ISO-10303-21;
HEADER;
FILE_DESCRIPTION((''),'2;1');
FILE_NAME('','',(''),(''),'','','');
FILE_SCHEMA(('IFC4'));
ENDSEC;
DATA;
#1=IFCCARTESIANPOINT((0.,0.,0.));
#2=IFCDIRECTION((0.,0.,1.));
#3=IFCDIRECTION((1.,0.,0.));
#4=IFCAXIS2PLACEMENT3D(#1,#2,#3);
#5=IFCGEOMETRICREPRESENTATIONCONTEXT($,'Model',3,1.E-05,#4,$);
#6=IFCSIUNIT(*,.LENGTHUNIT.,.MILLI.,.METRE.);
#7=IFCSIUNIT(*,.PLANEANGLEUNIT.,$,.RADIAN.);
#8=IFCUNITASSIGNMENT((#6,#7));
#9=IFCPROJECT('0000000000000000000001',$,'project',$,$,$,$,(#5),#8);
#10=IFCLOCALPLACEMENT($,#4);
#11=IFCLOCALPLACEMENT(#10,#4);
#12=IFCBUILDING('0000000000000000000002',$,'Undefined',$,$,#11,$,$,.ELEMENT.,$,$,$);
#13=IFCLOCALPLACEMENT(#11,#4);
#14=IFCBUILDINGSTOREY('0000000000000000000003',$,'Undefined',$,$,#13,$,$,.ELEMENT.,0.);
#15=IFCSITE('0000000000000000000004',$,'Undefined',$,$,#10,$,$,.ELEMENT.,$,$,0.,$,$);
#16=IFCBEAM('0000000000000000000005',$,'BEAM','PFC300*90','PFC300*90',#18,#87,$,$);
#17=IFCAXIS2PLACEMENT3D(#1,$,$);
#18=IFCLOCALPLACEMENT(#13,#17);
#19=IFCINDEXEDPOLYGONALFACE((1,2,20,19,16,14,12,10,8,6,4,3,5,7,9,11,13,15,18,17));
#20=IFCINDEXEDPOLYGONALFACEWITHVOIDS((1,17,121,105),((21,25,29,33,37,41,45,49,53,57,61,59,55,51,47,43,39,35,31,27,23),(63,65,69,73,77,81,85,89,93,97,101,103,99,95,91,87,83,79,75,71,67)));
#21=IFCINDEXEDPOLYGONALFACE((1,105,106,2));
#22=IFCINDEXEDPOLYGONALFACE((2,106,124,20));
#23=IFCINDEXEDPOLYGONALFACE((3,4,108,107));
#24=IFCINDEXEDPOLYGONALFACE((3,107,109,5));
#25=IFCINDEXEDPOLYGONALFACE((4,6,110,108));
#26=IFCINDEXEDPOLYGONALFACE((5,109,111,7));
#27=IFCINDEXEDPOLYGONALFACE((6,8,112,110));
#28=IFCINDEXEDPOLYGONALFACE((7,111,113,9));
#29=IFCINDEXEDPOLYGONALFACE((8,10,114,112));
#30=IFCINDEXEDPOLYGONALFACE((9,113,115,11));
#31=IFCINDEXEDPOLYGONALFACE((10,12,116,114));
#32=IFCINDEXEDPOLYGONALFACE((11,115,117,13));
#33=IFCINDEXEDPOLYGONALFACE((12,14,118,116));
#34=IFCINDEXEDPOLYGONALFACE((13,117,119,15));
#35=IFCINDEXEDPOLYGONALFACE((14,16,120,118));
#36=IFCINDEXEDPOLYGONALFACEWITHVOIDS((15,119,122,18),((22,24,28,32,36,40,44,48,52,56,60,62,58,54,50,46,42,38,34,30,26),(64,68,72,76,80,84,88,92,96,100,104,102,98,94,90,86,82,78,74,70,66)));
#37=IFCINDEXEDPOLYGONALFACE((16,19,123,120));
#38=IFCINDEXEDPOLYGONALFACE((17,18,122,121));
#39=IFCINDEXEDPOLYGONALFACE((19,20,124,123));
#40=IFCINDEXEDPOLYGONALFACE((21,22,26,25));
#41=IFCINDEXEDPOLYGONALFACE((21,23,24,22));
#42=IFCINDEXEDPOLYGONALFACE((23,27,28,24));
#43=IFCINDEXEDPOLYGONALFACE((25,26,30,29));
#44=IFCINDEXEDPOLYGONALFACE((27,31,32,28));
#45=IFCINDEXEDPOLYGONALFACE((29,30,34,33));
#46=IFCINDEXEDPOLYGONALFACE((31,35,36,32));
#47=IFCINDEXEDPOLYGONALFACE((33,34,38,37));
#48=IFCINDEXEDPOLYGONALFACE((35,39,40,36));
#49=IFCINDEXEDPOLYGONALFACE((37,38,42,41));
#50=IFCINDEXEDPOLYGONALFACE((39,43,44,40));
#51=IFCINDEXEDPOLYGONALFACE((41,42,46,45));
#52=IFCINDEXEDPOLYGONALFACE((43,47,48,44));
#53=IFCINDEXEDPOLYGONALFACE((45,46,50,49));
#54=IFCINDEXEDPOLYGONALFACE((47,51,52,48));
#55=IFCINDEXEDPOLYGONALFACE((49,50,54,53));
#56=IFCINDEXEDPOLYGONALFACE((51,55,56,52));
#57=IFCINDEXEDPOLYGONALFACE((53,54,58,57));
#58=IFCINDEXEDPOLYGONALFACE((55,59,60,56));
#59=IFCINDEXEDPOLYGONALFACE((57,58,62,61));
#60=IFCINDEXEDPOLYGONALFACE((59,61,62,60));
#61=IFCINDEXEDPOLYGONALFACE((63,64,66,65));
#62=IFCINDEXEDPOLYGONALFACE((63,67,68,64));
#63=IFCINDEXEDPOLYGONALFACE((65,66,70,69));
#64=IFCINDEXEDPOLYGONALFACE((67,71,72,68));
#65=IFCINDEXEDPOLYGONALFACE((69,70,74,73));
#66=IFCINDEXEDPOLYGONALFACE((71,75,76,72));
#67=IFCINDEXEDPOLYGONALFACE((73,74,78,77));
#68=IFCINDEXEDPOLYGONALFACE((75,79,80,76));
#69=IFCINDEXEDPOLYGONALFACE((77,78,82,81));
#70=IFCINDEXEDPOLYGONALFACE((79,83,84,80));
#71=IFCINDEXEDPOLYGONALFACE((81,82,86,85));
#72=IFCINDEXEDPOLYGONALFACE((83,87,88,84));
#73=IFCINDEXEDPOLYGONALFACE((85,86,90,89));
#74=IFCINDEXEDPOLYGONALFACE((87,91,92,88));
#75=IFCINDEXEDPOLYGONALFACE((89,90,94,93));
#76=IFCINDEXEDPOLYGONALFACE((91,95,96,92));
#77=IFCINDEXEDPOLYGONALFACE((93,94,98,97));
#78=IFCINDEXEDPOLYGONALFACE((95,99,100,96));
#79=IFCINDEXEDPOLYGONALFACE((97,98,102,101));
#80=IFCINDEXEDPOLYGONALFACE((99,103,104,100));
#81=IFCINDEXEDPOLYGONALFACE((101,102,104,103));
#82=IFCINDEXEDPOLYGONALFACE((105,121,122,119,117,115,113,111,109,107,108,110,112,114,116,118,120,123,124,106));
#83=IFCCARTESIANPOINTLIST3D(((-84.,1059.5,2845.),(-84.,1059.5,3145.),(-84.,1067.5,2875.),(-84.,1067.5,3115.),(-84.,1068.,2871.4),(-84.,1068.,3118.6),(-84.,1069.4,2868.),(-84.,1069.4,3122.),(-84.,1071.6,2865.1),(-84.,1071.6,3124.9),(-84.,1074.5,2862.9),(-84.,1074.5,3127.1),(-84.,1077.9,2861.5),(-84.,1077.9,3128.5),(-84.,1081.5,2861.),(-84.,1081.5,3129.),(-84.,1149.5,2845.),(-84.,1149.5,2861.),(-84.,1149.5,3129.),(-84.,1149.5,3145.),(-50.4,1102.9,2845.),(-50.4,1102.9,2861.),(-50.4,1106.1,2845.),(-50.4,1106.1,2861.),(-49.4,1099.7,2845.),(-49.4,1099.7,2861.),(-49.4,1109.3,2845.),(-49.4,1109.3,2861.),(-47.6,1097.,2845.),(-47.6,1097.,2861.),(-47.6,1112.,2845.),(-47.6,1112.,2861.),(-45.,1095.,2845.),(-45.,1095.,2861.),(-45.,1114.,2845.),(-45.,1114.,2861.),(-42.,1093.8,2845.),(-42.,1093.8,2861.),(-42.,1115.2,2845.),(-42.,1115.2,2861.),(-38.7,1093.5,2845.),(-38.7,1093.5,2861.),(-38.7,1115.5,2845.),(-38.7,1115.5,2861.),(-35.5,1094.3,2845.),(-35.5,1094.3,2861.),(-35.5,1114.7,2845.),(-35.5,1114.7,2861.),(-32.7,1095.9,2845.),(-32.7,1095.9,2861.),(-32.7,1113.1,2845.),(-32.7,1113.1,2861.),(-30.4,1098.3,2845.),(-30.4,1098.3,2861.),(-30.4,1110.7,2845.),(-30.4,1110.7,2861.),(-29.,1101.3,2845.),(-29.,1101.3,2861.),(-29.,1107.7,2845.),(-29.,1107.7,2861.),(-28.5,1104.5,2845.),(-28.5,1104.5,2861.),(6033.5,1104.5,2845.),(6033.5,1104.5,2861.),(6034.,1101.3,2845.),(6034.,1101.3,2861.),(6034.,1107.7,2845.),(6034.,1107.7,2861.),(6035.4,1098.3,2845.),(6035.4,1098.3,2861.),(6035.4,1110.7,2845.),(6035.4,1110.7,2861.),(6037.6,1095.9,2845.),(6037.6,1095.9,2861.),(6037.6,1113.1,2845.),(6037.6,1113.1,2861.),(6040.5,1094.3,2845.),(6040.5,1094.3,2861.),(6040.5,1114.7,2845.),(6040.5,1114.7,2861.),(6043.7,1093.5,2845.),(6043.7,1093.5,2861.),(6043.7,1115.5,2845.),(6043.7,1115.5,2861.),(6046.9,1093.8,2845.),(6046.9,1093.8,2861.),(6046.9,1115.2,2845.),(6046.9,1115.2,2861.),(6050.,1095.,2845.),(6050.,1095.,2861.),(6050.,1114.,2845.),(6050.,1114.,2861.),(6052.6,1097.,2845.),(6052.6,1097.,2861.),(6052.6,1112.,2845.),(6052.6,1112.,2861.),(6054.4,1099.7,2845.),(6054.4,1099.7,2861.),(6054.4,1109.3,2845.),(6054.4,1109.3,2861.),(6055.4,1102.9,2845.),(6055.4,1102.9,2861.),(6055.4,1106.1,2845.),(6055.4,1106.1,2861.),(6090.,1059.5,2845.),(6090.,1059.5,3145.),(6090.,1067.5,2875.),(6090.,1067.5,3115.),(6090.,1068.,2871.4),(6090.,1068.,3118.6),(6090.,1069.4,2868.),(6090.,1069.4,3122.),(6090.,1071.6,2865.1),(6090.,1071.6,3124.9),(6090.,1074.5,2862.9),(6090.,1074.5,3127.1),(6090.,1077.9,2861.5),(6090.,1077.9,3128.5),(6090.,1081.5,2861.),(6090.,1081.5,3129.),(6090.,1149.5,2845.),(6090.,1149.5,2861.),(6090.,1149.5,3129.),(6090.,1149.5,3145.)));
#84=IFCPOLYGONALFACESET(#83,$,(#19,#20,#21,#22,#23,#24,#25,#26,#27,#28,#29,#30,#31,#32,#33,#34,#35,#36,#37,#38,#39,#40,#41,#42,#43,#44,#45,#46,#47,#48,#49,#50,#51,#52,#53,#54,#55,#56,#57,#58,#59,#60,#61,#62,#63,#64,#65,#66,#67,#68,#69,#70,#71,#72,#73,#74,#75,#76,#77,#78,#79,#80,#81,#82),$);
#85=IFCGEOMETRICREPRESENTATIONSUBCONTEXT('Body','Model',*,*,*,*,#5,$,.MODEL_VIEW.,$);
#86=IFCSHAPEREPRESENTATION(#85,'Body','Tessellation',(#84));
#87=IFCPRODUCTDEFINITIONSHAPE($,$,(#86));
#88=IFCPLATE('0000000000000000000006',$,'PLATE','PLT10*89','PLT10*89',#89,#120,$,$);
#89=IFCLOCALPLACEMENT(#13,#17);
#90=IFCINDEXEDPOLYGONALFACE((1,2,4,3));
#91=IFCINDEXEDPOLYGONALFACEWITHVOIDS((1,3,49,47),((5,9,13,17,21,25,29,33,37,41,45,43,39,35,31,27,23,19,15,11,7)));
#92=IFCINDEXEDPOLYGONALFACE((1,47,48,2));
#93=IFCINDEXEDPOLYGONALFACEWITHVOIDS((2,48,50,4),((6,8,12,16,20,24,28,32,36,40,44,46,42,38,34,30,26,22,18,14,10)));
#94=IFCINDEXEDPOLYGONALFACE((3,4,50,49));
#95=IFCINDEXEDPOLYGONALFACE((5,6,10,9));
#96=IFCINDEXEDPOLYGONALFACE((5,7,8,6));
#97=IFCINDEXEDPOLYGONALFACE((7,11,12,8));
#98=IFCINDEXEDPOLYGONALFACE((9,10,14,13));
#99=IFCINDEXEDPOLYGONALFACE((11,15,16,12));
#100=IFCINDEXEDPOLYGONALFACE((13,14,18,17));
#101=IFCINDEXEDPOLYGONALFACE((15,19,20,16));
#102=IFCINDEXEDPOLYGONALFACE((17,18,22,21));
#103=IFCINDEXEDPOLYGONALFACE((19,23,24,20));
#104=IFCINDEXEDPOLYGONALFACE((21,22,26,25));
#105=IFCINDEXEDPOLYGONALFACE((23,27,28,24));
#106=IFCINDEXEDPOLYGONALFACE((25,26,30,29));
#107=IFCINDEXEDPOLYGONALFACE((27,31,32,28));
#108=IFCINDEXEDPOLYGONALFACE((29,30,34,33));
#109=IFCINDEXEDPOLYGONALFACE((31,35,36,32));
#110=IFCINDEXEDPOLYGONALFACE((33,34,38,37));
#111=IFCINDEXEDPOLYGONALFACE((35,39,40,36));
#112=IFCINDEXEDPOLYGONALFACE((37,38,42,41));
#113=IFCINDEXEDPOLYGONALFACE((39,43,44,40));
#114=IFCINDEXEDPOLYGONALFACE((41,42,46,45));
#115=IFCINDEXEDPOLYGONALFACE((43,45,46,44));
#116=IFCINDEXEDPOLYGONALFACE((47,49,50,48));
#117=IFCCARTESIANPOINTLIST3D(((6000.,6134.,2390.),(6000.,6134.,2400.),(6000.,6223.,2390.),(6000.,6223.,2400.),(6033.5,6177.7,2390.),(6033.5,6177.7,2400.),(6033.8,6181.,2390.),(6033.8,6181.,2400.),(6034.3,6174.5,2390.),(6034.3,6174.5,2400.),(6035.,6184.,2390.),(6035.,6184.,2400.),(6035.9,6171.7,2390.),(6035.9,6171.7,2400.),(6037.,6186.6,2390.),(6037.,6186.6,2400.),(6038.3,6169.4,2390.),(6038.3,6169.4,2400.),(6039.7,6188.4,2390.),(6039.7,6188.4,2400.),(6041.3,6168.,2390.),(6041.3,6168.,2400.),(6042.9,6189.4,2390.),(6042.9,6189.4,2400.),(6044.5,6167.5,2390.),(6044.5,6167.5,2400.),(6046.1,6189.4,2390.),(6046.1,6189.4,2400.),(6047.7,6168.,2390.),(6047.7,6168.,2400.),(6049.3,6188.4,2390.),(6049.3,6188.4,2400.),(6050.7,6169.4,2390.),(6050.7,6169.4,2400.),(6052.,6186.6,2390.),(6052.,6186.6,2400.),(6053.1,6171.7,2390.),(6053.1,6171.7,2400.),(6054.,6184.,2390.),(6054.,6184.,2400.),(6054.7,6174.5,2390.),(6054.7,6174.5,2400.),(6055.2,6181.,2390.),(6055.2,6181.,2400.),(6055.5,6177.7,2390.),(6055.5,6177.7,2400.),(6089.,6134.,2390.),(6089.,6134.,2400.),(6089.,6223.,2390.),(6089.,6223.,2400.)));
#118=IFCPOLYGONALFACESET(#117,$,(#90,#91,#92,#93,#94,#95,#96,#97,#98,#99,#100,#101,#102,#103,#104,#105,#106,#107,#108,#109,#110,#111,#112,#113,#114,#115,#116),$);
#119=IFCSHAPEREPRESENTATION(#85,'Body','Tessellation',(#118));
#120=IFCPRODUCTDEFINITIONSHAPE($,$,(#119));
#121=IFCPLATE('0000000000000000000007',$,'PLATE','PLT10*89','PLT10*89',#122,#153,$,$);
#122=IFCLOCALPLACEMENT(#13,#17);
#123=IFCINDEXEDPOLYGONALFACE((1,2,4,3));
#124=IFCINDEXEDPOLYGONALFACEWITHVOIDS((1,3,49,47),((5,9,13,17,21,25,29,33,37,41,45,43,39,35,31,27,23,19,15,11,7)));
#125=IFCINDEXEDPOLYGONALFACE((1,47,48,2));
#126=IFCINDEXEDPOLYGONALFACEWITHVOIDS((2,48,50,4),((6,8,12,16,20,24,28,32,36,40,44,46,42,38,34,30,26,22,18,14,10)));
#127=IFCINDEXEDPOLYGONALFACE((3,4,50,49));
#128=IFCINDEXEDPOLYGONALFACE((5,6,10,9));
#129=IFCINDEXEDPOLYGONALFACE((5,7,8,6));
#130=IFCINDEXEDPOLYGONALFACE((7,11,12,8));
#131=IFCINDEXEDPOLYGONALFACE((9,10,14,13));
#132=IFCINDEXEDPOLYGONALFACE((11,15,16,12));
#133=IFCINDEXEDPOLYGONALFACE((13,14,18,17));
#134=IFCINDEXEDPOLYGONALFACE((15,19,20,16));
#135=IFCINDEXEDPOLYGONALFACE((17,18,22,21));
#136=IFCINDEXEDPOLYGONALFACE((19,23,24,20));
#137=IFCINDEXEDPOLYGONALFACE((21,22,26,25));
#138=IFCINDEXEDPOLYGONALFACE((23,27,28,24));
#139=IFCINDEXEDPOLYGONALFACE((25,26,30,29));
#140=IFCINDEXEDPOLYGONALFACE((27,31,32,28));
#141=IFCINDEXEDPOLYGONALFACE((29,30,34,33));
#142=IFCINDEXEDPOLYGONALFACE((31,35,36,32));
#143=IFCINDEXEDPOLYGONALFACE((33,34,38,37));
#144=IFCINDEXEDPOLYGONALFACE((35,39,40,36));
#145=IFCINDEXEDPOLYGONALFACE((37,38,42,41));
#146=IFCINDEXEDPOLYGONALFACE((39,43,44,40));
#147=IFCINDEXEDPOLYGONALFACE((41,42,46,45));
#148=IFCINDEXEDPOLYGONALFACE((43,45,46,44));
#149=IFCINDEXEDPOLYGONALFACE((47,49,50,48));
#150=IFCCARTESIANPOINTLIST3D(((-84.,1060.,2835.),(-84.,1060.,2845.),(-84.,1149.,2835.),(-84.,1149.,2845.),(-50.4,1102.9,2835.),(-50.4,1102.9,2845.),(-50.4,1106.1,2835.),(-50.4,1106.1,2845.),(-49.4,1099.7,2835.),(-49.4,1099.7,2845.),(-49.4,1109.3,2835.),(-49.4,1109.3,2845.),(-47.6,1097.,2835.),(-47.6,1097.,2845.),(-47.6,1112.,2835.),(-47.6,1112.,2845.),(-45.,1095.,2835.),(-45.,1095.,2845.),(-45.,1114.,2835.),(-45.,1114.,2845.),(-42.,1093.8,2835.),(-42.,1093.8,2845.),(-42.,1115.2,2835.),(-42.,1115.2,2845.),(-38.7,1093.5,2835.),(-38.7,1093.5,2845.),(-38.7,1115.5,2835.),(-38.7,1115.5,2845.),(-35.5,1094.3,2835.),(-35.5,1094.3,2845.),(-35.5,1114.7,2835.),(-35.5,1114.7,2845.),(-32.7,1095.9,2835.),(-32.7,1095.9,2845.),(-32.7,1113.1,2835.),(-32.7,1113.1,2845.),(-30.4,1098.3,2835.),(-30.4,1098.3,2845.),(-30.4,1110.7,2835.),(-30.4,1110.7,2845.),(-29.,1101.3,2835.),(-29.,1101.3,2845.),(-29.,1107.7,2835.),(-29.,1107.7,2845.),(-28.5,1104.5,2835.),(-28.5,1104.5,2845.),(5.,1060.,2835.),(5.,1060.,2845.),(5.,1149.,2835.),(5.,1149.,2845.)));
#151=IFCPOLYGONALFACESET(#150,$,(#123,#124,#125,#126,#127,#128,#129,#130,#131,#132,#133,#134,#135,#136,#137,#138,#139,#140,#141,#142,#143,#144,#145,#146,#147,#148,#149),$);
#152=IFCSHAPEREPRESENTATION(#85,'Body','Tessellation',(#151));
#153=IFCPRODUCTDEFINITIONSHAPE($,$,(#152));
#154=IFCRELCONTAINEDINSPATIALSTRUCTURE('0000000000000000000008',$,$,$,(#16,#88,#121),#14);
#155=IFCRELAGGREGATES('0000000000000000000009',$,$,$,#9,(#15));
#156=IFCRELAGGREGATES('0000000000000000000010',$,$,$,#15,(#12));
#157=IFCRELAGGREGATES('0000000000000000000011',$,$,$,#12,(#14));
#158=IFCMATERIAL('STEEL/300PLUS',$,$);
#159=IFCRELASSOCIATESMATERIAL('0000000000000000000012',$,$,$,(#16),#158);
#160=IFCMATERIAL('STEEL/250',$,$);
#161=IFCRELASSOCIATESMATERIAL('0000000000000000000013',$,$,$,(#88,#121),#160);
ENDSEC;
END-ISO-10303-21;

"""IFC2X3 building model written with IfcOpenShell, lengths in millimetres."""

from ifc_helpers import new_model, si_unit, frame, origin_with_axes, origin_2d_with_axis, place, context, subcontext, project, spatial, polyline, circle, u_section, outline, extrude, source, transform, mapped, material, element, save


model = new_model("IFC2X3")

# Units and contexts
model_context = context("Model", 3, precision=1e-05, world=origin_with_axes())
body_context = subcontext(model_context, "Body", "Model", "MODEL_VIEW")
ifc_project = project(units=[si_unit("LENGTHUNIT", "METRE", prefix="MILLI"), si_unit("PLANEANGLEUNIT", "RADIAN")], contexts=[model_context])

# Site, building, storey
site_placement = place(None, origin_with_axes())
site = spatial("IfcSite", under=ifc_project, at=site_placement, Name="Undefined", CompositionType="ELEMENT", RefElevation=0.0)
building_placement = place(site_placement, origin_with_axes())
building = spatial("IfcBuilding", under=site, at=building_placement, Name="Undefined", CompositionType="ELEMENT")
storey_placement = place(building_placement, origin_with_axes())
storey = spatial("IfcBuildingStorey", under=building, at=storey_placement, Name="Undefined", CompositionType="ELEMENT", Elevation=0.0)

# Shared definitions
ifc_material_1 = material(Name="STEEL/300PLUS")

# Beam, openings
beam_1_placement = place(storey_placement, frame((-84.0, 1104.5, 2995.0), z_axis=(0.0, 0.0, -1.0), x_axis=(1.0, 0.0, 0.0)))
beam_1 = element("IfcBeam", 1, at=beam_1_placement, inside=storey, material=ifc_material_1, Name="BEAM", Description="PFC300*90", ObjectType="PFC300*90", context=body_context, shape_type="SweptSolid", body=[
    extrude(u_section(Depth=300.0, FlangeWidth=90.0, WebThickness=8.0, FlangeThickness=16.0, FilletRadius=14.0, at=origin_2d_with_axis()), frame((6174.0, 0.0, 0.0), z_axis=(-1.0, 0.0, 0.0), x_axis=(0.0, -1.0, 0.0)), (0.0, 0.0, 1.0), 6174.0),
])
shared_shape_1 = source(origin_with_axes(), body_context, "Body", "SweptSolid", [
    extrude(circle(Radius=11.0, at=origin_2d_with_axis()), frame((0.0, -0.1, 0.0), z_axis=(0.0, 1.0, 0.0), x_axis=(1.0, 0.0, 0.0)), (0.0, 0.0, 1.0), 16.2),
])
opening_1_placement = place(storey_placement, frame((-39.5, 1104.5, 2845.0), z_axis=(0.0, -1.0, 0.0), x_axis=(1.0, 0.0, 0.0)))
element("IfcOpeningElement", 2, at=opening_1_placement, cuts=beam_1, ObjectType="Opening", context=body_context, shape_type="MappedRepresentation", body=[
    mapped(shared_shape_1, transform((0.0, 0.0, 0.0))),
])
opening_2_placement = place(storey_placement, frame((6044.5, 1104.5, 2845.0), z_axis=(0.0, 1.0, 0.0), x_axis=(-1.0, 0.0, 0.0)))
element("IfcOpeningElement", 3, at=opening_2_placement, cuts=beam_1, ObjectType="Opening", context=body_context, shape_type="MappedRepresentation", body=[
    mapped(shared_shape_1, transform((0.0, 0.0, 0.0))),
])

# Plates, openings
ifc_material_2 = material(Name="STEEL/250")
plate_1_placement = place(storey_placement, frame((6089.0, 6223.0, 2395.0), z_axis=(0.0, 0.000008, 1.0), x_axis=(-1.0, 0.0, 0.0)))
plate_1 = element("IfcPlate", 4, at=plate_1_placement, inside=storey, material=ifc_material_2, Name="PLATE", Description="PLT10*89", ObjectType="PLT10*89", context=body_context, shape_type="SweptSolid", body=[
    extrude(outline(polyline([(0.0, 0.0), (89.0, 0.0), (89.0, 89.0), (0.0, 89.0), (0.0, 0.0)])), frame((0.0, 0.0, -5.0), z_axis=(0.0, 0.0, 1.0), x_axis=(1.0, 0.0, 0.0)), (0.0, 0.0, 1.0), 10.0),
])
shared_shape_2 = source(origin_with_axes(), body_context, "Body", "SweptSolid", [
    extrude(circle(Radius=11.0, at=origin_2d_with_axis()), frame((0.0, 4.9, 0.0), z_axis=(0.0, 1.0, 0.0), x_axis=(1.0, 0.0, 0.0)), (0.0, 0.0, 1.0), 15.1),
])
opening_3_placement = place(storey_placement, frame((6044.5, 6178.5, 2385.0), z_axis=(-1.0, 0.0, 0.0), x_axis=(0.0, -1.0, 0.000008)))
element("IfcOpeningElement", 5, at=opening_3_placement, cuts=plate_1, ObjectType="Opening", context=body_context, shape_type="MappedRepresentation", body=[
    mapped(shared_shape_2, transform((0.0, 0.0, 0.0))),
])
plate_2_placement = place(storey_placement, frame((-84.0, 1149.0, 2840.0), z_axis=(0.0, 0.0, 1.0), x_axis=(0.0, -1.0, 0.0)))
plate_2 = element("IfcPlate", 6, at=plate_2_placement, inside=storey, material=ifc_material_2, Name="PLATE", Description="PLT10*89", ObjectType="PLT10*89", context=body_context, shape_type="SweptSolid", body=[
    extrude(outline(polyline([(0.0, 0.0), (89.0, 0.0), (89.0, 89.0), (0.0, 89.0), (0.0, 0.0)])), frame((0.0, 0.0, -5.0), z_axis=(0.0, 0.0, 1.0), x_axis=(1.0, 0.0, 0.0)), (0.0, 0.0, 1.0), 10.0),
])
shared_shape_3 = source(origin_with_axes(), body_context, "Body", "SweptSolid", [
    extrude(circle(Radius=11.0, at=origin_2d_with_axis()), frame((0.0, -10.1, 0.0), z_axis=(0.0, 1.0, 0.0), x_axis=(1.0, 0.0, 0.0)), (0.0, 0.0, 1.0), 20.3),
])
opening_4_placement = place(storey_placement, frame((-39.5, 1104.5, 2845.0), z_axis=(0.0, -1.0, 0.0), x_axis=(1.0, 0.0, 0.0)))
element("IfcOpeningElement", 7, at=opening_4_placement, cuts=plate_2, ObjectType="Opening", context=body_context, shape_type="MappedRepresentation", body=[
    mapped(shared_shape_3, transform((0.0, 0.0, 0.0))),
])

save(model, "model.ifc")
